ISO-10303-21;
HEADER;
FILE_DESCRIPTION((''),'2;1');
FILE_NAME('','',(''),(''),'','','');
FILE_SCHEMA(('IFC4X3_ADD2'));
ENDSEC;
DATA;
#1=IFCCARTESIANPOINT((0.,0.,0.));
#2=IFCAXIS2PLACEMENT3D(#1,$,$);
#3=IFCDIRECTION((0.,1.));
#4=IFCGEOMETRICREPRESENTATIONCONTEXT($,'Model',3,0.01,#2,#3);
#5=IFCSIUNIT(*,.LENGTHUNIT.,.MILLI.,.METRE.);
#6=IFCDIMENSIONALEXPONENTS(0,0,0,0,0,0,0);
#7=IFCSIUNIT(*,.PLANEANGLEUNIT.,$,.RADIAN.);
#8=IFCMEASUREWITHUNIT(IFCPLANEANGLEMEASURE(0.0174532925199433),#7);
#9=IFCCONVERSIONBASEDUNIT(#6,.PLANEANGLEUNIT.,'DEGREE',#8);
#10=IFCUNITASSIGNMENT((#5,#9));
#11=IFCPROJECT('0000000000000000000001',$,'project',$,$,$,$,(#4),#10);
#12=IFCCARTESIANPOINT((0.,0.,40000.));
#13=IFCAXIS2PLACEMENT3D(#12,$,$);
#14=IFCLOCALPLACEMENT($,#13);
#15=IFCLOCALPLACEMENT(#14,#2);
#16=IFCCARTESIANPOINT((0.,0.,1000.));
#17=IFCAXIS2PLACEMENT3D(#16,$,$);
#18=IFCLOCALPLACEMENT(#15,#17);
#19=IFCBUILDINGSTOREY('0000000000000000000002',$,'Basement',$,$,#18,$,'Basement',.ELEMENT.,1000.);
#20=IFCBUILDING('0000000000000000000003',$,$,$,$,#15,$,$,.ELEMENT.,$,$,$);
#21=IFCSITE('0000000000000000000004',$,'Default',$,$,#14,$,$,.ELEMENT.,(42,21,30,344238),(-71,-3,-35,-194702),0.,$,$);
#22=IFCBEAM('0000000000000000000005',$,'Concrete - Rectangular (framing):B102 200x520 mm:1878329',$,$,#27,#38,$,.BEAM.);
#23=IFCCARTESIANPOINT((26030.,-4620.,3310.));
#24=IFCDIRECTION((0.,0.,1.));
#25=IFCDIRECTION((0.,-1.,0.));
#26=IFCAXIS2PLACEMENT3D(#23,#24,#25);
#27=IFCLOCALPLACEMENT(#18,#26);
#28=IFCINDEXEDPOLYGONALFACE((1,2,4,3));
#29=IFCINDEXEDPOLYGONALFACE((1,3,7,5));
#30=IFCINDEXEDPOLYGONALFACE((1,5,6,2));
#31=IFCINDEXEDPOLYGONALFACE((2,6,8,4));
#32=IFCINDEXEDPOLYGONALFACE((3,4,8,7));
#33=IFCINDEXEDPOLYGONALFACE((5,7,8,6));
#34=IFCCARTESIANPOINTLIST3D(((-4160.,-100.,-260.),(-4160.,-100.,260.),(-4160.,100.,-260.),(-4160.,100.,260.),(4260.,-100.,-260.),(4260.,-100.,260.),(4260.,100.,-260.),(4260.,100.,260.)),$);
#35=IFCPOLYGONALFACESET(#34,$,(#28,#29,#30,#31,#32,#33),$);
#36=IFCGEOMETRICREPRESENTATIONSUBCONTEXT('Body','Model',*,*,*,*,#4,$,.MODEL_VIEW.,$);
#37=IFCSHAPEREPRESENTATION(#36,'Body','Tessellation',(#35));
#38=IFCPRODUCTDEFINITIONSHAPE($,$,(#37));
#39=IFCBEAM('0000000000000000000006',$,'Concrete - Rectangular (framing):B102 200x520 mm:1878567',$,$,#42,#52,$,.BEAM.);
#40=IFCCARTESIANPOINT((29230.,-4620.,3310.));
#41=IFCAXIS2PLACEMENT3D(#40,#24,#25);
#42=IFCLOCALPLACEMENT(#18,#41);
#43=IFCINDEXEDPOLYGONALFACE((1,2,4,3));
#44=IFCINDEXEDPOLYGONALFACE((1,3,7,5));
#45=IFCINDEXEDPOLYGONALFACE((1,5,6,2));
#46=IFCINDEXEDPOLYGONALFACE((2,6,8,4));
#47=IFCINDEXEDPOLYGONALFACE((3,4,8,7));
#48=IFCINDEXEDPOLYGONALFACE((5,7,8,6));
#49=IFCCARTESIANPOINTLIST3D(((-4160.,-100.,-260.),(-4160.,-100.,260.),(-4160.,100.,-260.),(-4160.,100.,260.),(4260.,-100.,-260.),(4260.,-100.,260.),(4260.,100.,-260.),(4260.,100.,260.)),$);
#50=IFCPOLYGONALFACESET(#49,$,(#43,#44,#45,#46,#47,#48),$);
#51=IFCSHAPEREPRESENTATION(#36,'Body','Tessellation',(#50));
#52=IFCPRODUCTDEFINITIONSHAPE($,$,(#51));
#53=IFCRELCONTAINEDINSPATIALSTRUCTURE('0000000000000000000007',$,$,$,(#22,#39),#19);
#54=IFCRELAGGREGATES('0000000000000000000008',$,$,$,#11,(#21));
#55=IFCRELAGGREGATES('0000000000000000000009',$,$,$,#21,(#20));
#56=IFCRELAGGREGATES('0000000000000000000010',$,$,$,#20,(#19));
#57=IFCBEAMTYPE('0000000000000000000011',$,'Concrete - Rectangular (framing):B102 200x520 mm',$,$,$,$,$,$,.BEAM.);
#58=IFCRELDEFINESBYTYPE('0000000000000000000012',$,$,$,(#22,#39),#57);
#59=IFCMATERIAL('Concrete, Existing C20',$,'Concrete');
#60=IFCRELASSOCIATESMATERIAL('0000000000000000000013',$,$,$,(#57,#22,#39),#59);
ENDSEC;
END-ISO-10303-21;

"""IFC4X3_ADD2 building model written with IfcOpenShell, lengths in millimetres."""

from ifc_helpers import new_model, entity, si_unit, converted_unit, direction, frame, origin, origin_2d_with_axis, place, context, subcontext, project, spatial, rectangle, extrude, source, transform, mapped, material, material_profile, profile_set, profile_usage, type_object, type_shapes, element, save


model = new_model("IFC4X3_ADD2")

# Units and contexts
model_context = context("Model", 3, precision=0.01, world=origin(), true_north=direction((0.0, 1.0)))
body_context = subcontext(model_context, "Body", "Model", "MODEL_VIEW")
ifc_project = project(units=[si_unit("LENGTHUNIT", "METRE", prefix="MILLI"), converted_unit("PLANEANGLEUNIT", "DEGREE", entity("IfcPlaneAngleMeasure", 0.0174532925199433), si_unit("PLANEANGLEUNIT", "RADIAN"), dimensions=[0, 0, 0, 0, 0, 0, 0])], contexts=[model_context])

# Site, building, storey
site_placement = place(None, frame((0.0, 0.0, 40000.0)))
site = spatial("IfcSite", under=ifc_project, at=site_placement, Name="Default", CompositionType="ELEMENT", RefLatitude=(42, 21, 30, 344238), RefLongitude=(-71, -3, -35, -194702), RefElevation=0.0)
building_placement = place(site_placement, origin())
building = spatial("IfcBuilding", under=site, at=building_placement, CompositionType="ELEMENT")
storey_placement = place(building_placement, frame((0.0, 0.0, 1000.0)))
storey = spatial("IfcBuildingStorey", under=building, at=storey_placement, Name="Basement", LongName="Basement", CompositionType="ELEMENT", Elevation=1000.0)

# Shared definitions
ifc_material_1 = material(Name="Concrete, Existing C20", Category="Concrete")

# Beams
ifc_material_profile_1 = material_profile(ifc_material_1, rectangle(XDim=8519.8, YDim=200.0, at=origin_2d_with_axis()), Name="B102 200x520 mm")
ifc_profile_set_1 = profile_set([ifc_material_profile_1], Name="B102 200x520 mm")
ifc_profile_usage_1 = profile_usage(ifc_profile_set_1, cardinal=8)
beam_type_1 = type_object("IfcBeamType", Name="Concrete - Rectangular (framing):B102 200x520 mm", PredefinedType="BEAM", material=ifc_profile_set_1)
shared_shape_1 = source(origin(), body_context, "Body", "SweptSolid", [
    extrude(rectangle(XDim=8420.0, YDim=200.0, at=origin_2d_with_axis()), frame((50.0, 0.0, -260.0), z_axis=(0.0, 0.0, 1.0), x_axis=(-1.0, 0.0, 0.0)), (0.0, 0.0, 1.0), 520.0),
])
type_shapes(beam_type_1, [shared_shape_1])
for number, where, z_axis, x_axis, name in (
    (1, (26030.0, -4620.0, 3310.0), (0.0, 0.0, 1.0), (0.0, -1.0, 0.0), "Concrete - Rectangular (framing):B102 200x520 mm:1878329"),
    (2, (29230.0, -4620.0, 3310.0), (0.0, 0.0, 1.0), (0.0, -1.0, 0.0), "Concrete - Rectangular (framing):B102 200x520 mm:1878567"),
):
    element("IfcBeam", number, at=place(storey_placement, frame(where, z_axis=z_axis, x_axis=x_axis)), inside=storey, type_object=beam_type_1, material=ifc_profile_usage_1, Name=name, PredefinedType="BEAM", context=body_context, shape_type="MappedRepresentation", body=[
        mapped(shared_shape_1, transform((0.0, 0.0, 0.0), scale=1.0)),
    ])

save(model, "model.ifc")
